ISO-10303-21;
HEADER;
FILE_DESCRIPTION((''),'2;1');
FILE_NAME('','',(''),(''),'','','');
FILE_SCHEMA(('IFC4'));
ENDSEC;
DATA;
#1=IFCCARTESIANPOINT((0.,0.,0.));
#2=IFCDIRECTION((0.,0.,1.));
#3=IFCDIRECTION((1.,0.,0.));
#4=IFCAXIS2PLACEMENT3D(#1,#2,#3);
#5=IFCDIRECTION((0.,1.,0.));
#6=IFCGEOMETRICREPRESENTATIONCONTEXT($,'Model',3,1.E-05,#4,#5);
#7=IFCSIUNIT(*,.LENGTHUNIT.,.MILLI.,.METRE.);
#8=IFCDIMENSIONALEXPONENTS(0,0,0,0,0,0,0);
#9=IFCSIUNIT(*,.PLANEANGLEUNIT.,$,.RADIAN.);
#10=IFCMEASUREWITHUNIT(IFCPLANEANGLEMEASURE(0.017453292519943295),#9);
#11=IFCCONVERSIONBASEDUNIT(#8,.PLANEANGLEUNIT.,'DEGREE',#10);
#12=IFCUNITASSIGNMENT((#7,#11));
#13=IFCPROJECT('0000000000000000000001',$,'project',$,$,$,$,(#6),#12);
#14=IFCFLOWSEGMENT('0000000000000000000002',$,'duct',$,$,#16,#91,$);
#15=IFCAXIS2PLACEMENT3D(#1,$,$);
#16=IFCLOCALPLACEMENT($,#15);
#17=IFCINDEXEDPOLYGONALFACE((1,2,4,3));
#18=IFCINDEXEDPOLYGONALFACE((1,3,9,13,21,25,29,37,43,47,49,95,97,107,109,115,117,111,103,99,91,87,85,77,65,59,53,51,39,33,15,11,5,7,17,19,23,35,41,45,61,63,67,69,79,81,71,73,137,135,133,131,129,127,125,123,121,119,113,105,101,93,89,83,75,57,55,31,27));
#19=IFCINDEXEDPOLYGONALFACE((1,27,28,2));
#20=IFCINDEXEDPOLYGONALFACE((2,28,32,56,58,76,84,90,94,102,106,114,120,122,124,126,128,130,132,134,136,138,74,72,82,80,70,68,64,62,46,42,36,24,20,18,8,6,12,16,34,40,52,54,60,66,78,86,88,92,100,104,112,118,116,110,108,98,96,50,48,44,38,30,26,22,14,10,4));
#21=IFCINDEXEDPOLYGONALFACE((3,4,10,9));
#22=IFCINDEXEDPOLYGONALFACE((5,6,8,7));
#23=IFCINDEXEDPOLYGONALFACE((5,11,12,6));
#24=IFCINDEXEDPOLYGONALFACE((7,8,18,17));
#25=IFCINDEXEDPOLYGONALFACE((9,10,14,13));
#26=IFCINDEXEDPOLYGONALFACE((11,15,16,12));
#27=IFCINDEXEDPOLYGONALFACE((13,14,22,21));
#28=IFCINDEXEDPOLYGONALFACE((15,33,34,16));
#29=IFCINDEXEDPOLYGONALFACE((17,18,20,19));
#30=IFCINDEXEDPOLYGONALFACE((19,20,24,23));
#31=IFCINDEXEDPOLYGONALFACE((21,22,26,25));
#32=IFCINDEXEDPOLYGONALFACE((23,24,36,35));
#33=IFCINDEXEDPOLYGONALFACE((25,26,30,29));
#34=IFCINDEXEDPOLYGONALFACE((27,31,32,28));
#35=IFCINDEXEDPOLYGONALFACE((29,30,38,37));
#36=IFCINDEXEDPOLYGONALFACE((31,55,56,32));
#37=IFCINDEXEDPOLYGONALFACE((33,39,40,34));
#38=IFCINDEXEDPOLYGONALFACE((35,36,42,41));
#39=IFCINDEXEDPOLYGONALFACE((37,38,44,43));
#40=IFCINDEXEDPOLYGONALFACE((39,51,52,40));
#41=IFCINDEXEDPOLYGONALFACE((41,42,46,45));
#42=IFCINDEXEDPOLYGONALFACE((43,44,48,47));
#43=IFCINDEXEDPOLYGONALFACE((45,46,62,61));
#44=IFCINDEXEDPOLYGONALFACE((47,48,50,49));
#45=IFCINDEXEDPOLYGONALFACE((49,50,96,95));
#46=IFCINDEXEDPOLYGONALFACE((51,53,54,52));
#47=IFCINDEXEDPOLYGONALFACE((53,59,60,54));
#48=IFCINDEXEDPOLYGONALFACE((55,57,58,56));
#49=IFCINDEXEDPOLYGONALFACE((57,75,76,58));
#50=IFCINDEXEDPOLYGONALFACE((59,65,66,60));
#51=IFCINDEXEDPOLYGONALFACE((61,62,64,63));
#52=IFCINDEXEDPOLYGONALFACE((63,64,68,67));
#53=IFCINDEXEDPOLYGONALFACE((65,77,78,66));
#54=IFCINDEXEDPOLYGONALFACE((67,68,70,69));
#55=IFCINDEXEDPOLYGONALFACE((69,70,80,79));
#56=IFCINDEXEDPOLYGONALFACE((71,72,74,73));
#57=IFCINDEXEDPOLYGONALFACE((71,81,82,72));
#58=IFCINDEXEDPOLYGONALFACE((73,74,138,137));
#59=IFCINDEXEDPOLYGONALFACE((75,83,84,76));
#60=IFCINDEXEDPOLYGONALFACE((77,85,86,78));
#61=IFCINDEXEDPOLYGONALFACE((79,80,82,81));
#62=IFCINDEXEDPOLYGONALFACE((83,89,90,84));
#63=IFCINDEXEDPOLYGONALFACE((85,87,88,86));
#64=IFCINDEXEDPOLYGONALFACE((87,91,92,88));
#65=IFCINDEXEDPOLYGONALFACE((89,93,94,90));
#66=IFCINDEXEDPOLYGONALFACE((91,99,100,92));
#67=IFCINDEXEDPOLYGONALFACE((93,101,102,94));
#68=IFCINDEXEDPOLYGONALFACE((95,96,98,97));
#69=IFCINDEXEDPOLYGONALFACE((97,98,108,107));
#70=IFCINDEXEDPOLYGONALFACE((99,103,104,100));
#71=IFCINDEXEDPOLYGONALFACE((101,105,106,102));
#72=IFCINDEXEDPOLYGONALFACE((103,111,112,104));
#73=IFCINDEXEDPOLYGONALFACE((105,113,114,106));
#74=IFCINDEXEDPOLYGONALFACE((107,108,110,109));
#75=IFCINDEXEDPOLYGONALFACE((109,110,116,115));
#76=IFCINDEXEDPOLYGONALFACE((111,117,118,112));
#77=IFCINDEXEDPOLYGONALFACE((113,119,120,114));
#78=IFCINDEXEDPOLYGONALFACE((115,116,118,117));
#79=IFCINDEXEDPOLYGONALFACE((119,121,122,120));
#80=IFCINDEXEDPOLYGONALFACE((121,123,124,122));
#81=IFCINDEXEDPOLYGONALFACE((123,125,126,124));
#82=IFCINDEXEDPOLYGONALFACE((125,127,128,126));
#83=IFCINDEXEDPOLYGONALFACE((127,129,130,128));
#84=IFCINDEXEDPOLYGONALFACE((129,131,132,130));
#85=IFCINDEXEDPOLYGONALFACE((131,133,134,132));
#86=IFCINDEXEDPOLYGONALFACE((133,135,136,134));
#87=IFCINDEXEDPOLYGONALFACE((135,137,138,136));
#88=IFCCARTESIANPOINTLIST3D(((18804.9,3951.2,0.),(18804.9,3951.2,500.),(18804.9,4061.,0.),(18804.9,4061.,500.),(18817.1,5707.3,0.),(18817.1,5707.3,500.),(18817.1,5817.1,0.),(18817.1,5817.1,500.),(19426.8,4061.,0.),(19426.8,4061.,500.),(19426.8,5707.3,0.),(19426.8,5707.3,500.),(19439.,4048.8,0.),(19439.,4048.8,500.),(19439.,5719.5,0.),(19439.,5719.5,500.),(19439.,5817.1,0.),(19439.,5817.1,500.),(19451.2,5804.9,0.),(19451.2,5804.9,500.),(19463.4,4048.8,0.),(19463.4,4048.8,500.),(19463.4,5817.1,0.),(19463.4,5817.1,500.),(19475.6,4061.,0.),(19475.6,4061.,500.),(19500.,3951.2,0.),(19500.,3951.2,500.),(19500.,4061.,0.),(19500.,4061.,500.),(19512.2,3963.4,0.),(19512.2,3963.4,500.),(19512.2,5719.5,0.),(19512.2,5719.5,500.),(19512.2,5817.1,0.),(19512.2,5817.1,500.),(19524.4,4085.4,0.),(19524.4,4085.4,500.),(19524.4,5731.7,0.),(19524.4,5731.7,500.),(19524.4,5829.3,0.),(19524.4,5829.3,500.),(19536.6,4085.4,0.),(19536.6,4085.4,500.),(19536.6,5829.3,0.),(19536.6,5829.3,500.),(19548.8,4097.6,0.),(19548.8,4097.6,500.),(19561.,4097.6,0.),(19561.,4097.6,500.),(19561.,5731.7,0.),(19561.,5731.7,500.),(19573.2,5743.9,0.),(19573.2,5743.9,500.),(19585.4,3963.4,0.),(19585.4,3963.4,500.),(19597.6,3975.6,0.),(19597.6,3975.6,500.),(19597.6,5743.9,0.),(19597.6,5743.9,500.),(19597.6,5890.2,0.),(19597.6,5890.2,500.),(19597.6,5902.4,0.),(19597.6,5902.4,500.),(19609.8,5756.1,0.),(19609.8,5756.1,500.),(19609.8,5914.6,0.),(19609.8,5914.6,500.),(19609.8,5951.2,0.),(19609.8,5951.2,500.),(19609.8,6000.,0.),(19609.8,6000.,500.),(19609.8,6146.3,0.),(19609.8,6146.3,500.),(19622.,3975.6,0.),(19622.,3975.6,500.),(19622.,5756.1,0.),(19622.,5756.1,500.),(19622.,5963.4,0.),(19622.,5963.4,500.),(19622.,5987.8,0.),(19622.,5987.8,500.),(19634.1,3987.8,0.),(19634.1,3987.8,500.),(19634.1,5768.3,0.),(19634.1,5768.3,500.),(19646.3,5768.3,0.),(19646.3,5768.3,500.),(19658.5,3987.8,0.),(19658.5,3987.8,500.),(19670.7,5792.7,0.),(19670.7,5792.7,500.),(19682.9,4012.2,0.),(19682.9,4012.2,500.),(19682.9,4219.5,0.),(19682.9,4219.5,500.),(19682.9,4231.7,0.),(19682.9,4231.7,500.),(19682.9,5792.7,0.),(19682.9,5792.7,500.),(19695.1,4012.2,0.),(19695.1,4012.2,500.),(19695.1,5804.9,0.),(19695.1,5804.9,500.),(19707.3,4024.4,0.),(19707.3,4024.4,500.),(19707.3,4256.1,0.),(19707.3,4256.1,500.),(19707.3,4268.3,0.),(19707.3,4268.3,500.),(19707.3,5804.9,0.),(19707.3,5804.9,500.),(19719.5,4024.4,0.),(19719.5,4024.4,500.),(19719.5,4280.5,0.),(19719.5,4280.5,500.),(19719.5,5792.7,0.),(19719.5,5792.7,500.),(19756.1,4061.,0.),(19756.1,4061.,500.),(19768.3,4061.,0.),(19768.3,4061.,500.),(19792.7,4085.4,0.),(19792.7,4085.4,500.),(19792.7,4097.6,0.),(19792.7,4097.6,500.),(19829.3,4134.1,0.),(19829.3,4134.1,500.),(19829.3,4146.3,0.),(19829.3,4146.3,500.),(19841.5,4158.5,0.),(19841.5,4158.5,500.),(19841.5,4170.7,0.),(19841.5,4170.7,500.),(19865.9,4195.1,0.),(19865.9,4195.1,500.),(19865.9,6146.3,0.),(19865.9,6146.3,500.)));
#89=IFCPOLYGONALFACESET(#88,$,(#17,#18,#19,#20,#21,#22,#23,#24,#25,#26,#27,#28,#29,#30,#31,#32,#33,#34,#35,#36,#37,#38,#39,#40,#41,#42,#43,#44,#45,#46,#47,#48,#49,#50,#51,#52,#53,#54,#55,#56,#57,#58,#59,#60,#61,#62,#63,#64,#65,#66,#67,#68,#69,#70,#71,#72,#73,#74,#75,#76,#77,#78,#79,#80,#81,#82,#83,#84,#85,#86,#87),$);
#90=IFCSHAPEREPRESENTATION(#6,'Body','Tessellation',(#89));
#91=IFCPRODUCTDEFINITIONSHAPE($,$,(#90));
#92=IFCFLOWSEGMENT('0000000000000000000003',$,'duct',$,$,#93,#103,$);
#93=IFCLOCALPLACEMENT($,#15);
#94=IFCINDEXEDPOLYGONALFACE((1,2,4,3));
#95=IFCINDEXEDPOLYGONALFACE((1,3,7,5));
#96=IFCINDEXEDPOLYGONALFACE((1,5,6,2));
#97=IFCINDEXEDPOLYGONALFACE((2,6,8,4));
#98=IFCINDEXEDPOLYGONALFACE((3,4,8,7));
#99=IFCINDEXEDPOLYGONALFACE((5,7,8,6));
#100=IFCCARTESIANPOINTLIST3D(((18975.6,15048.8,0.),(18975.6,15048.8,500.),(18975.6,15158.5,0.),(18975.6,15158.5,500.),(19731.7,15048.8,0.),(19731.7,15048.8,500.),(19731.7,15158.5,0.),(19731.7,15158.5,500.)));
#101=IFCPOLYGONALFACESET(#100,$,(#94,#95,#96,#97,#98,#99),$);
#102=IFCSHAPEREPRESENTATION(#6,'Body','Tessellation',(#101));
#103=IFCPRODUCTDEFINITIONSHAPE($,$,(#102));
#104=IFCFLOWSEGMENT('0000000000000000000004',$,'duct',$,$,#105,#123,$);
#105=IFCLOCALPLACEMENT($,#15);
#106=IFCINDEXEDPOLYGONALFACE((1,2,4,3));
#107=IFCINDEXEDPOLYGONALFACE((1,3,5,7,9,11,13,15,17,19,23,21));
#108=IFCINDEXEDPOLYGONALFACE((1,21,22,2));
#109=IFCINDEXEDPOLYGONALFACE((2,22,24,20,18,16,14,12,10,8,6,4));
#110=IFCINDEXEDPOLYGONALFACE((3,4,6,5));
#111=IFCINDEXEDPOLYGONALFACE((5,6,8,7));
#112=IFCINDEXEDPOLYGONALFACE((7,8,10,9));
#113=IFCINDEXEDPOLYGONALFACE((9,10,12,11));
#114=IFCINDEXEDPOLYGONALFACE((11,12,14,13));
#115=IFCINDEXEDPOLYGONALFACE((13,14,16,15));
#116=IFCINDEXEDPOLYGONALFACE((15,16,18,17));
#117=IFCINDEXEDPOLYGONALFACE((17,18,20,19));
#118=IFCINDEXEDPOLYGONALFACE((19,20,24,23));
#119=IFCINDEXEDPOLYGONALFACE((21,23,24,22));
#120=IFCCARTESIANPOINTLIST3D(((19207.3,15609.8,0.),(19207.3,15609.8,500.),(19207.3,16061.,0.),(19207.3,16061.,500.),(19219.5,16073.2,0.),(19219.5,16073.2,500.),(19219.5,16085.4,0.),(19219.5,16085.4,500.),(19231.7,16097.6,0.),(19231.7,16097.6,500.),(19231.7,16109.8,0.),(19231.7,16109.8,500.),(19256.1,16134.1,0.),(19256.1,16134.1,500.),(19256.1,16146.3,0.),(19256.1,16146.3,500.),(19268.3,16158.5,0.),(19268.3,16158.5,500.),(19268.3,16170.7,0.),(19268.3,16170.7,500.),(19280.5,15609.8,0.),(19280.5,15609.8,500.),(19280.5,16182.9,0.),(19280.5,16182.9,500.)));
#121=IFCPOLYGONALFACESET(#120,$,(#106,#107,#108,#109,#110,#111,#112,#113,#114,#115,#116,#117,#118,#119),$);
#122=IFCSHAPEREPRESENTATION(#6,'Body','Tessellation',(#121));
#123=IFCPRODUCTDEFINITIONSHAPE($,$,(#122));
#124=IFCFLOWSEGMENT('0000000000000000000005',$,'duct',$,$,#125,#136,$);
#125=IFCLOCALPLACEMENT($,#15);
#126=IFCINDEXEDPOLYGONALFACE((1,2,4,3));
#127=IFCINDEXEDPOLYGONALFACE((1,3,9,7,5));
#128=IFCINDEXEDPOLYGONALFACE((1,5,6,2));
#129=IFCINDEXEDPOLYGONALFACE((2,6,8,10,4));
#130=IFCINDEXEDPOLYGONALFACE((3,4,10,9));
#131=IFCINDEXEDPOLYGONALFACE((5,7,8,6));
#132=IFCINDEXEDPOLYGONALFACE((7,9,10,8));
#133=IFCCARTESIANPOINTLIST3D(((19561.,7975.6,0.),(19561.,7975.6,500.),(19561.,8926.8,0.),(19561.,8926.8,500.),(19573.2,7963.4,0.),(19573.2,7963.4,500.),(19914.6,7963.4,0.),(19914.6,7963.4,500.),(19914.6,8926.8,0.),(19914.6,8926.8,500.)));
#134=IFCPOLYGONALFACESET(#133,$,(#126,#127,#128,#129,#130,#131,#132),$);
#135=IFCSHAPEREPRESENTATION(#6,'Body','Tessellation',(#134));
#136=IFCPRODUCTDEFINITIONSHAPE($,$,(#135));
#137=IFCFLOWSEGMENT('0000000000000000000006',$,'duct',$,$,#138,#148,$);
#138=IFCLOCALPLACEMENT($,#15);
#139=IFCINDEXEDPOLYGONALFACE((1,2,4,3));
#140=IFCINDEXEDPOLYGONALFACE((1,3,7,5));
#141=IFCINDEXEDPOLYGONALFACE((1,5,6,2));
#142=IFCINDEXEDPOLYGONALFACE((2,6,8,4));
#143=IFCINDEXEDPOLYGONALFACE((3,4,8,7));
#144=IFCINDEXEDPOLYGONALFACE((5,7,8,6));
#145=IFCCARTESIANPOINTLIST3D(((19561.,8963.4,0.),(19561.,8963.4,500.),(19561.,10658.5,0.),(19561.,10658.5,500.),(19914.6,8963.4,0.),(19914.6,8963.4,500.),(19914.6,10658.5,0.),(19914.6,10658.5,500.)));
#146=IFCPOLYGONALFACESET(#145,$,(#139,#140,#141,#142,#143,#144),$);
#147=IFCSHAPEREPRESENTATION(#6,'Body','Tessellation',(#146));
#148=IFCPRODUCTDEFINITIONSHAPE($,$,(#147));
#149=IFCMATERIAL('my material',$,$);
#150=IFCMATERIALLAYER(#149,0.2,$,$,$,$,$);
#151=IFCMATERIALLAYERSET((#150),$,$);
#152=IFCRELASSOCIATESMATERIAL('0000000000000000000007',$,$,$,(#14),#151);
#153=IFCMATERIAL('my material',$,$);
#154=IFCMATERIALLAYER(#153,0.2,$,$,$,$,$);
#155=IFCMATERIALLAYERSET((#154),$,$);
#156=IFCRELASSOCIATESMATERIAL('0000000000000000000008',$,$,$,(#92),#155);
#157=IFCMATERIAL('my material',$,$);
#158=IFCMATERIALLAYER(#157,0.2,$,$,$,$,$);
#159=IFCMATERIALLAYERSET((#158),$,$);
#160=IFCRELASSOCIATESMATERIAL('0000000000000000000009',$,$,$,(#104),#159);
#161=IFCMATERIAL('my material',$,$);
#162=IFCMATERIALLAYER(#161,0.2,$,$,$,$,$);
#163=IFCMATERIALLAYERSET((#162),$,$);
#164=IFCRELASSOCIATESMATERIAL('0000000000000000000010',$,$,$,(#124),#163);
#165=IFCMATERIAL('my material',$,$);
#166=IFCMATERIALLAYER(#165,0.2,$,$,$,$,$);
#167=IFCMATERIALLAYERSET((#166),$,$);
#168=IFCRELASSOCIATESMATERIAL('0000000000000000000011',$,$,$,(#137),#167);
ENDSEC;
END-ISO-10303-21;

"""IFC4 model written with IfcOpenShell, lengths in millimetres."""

from ifc_helpers import new_model, entity, si_unit, converted_unit, direction, origin_with_axes, place, context, project, polyline, outline, extrude, material, layer, layer_set, layer_usage, element, save


model = new_model("IFC4")

# Units and contexts
model_context = context("Model", 3, precision=1e-05, world=origin_with_axes(), true_north=direction((0.0, 1.0, 0.0)))
ifc_project = project(units=[si_unit("LENGTHUNIT", "METRE", prefix="MILLI"), converted_unit("PLANEANGLEUNIT", "DEGREE", entity("IfcPlaneAngleMeasure", 0.017453292519943295), si_unit("PLANEANGLEUNIT", "RADIAN"), dimensions=[0, 0, 0, 0, 0, 0, 0])], contexts=[model_context])

# Flow segments
ifc_material_1 = material(Name="my material")
ifc_layer_1 = layer(ifc_material_1, 0.2)
ifc_layer_set_1 = layer_set([ifc_layer_1])
ifc_layer_usage_1 = layer_usage(ifc_layer_set_1, "AXIS2", "POSITIVE", -0.1)
flow_segment_1_placement = place(None, origin_with_axes())
element("IfcFlowSegment", 1, at=flow_segment_1_placement, material=ifc_layer_usage_1, Name="duct", context=model_context, shape_type="SweptSolid", body=[
    extrude(outline(polyline([(18804.9, 3951.2), (19500.0, 3951.2), (19512.2, 3963.4), (19585.4, 3963.4), (19597.6, 3975.6), (19622.0, 3975.6), (19634.1, 3987.8), (19658.5, 3987.8), (19682.9, 4012.2), (19695.1, 4012.2), (19707.3, 4024.4), (19719.5, 4024.4), (19756.1, 4061.0), (19768.3, 4061.0), (19792.7, 4085.4), (19792.7, 4097.6), (19829.3, 4134.1), (19829.3, 4146.3), (19841.5, 4158.5), (19841.5, 4170.7), (19865.9, 4195.1), (19865.9, 6146.3), (19609.8, 6146.3), (19609.8, 6000.0), (19622.0, 5987.8), (19622.0, 5963.4), (19609.8, 5951.2), (19609.8, 5914.6), (19597.6, 5902.4), (19597.6, 5890.2), (19536.6, 5829.3), (19524.4, 5829.3), (19512.2, 5817.1), (19463.4, 5817.1), (19451.2, 5804.9), (19439.0, 5817.1), (18817.1, 5817.1), (18817.1, 5707.3), (19426.8, 5707.3), (19439.0, 5719.5), (19512.2, 5719.5), (19524.4, 5731.7), (19561.0, 5731.7), (19573.2, 5743.9), (19597.6, 5743.9), (19609.8, 5756.1), (19622.0, 5756.1), (19634.1, 5768.3), (19646.3, 5768.3), (19670.7, 5792.7), (19682.9, 5792.7), (19695.1, 5804.9), (19707.3, 5804.9), (19719.5, 5792.7), (19719.5, 4280.5), (19707.3, 4268.3), (19707.3, 4256.1), (19682.9, 4231.7), (19682.9, 4219.5), (19561.0, 4097.6), (19548.8, 4097.6), (19536.6, 4085.4), (19524.4, 4085.4), (19500.0, 4061.0), (19475.6, 4061.0), (19463.4, 4048.8), (19439.0, 4048.8), (19426.8, 4061.0), (18804.9, 4061.0), (18804.9, 3951.2)])), origin_with_axes(), (0.0, 0.0, 1.0), 500.0),
])
ifc_material_2 = material(Name="my material")
ifc_layer_2 = layer(ifc_material_2, 0.2)
ifc_layer_set_2 = layer_set([ifc_layer_2])
ifc_layer_usage_2 = layer_usage(ifc_layer_set_2, "AXIS2", "POSITIVE", -0.1)
flow_segment_2_placement = place(None, origin_with_axes())
element("IfcFlowSegment", 2, at=flow_segment_2_placement, material=ifc_layer_usage_2, Name="duct", context=model_context, shape_type="SweptSolid", body=[
    extrude(outline(polyline([(18975.6, 15048.8), (19731.7, 15048.8), (19731.7, 15158.5), (18975.6, 15158.5), (18975.6, 15048.8)])), origin_with_axes(), (0.0, 0.0, 1.0), 500.0),
])
ifc_material_3 = material(Name="my material")
ifc_layer_3 = layer(ifc_material_3, 0.2)
ifc_layer_set_3 = layer_set([ifc_layer_3])
ifc_layer_usage_3 = layer_usage(ifc_layer_set_3, "AXIS2", "POSITIVE", -0.1)
flow_segment_3_placement = place(None, origin_with_axes())
element("IfcFlowSegment", 3, at=flow_segment_3_placement, material=ifc_layer_usage_3, Name="duct", context=model_context, shape_type="SweptSolid", body=[
    extrude(outline(polyline([(19207.3, 15609.8), (19280.5, 15609.8), (19280.5, 16195.1), (19280.5, 16182.9), (19268.3, 16170.7), (19268.3, 16158.5), (19256.1, 16146.3), (19256.1, 16134.1), (19231.7, 16109.8), (19231.7, 16097.6), (19219.5, 16085.4), (19219.5, 16073.2), (19207.3, 16061.0), (19207.3, 15609.8)])), origin_with_axes(), (0.0, 0.0, 1.0), 500.0),
])
ifc_material_4 = material(Name="my material")
ifc_layer_4 = layer(ifc_material_4, 0.2)
ifc_layer_set_4 = layer_set([ifc_layer_4])
ifc_layer_usage_4 = layer_usage(ifc_layer_set_4, "AXIS2", "POSITIVE", -0.1)
flow_segment_4_placement = place(None, origin_with_axes())
element("IfcFlowSegment", 4, at=flow_segment_4_placement, material=ifc_layer_usage_4, Name="duct", context=model_context, shape_type="SweptSolid", body=[
    extrude(outline(polyline([(19561.0, 7975.6), (19573.2, 7963.4), (19914.6, 7963.4), (19914.6, 8926.8), (19561.0, 8926.8), (19561.0, 7975.6)])), origin_with_axes(), (0.0, 0.0, 1.0), 500.0),
])
ifc_material_5 = material(Name="my material")
ifc_layer_5 = layer(ifc_material_5, 0.2)
ifc_layer_set_5 = layer_set([ifc_layer_5])
ifc_layer_usage_5 = layer_usage(ifc_layer_set_5, "AXIS2", "POSITIVE", -0.1)
flow_segment_5_placement = place(None, origin_with_axes())
element("IfcFlowSegment", 5, at=flow_segment_5_placement, material=ifc_layer_usage_5, Name="duct", context=model_context, shape_type="SweptSolid", body=[
    extrude(outline(polyline([(19561.0, 8963.4), (19914.6, 8963.4), (19914.6, 10658.5), (19561.0, 10658.5), (19561.0, 8963.4)])), origin_with_axes(), (0.0, 0.0, 1.0), 500.0),
])

save(model, "model.ifc")
